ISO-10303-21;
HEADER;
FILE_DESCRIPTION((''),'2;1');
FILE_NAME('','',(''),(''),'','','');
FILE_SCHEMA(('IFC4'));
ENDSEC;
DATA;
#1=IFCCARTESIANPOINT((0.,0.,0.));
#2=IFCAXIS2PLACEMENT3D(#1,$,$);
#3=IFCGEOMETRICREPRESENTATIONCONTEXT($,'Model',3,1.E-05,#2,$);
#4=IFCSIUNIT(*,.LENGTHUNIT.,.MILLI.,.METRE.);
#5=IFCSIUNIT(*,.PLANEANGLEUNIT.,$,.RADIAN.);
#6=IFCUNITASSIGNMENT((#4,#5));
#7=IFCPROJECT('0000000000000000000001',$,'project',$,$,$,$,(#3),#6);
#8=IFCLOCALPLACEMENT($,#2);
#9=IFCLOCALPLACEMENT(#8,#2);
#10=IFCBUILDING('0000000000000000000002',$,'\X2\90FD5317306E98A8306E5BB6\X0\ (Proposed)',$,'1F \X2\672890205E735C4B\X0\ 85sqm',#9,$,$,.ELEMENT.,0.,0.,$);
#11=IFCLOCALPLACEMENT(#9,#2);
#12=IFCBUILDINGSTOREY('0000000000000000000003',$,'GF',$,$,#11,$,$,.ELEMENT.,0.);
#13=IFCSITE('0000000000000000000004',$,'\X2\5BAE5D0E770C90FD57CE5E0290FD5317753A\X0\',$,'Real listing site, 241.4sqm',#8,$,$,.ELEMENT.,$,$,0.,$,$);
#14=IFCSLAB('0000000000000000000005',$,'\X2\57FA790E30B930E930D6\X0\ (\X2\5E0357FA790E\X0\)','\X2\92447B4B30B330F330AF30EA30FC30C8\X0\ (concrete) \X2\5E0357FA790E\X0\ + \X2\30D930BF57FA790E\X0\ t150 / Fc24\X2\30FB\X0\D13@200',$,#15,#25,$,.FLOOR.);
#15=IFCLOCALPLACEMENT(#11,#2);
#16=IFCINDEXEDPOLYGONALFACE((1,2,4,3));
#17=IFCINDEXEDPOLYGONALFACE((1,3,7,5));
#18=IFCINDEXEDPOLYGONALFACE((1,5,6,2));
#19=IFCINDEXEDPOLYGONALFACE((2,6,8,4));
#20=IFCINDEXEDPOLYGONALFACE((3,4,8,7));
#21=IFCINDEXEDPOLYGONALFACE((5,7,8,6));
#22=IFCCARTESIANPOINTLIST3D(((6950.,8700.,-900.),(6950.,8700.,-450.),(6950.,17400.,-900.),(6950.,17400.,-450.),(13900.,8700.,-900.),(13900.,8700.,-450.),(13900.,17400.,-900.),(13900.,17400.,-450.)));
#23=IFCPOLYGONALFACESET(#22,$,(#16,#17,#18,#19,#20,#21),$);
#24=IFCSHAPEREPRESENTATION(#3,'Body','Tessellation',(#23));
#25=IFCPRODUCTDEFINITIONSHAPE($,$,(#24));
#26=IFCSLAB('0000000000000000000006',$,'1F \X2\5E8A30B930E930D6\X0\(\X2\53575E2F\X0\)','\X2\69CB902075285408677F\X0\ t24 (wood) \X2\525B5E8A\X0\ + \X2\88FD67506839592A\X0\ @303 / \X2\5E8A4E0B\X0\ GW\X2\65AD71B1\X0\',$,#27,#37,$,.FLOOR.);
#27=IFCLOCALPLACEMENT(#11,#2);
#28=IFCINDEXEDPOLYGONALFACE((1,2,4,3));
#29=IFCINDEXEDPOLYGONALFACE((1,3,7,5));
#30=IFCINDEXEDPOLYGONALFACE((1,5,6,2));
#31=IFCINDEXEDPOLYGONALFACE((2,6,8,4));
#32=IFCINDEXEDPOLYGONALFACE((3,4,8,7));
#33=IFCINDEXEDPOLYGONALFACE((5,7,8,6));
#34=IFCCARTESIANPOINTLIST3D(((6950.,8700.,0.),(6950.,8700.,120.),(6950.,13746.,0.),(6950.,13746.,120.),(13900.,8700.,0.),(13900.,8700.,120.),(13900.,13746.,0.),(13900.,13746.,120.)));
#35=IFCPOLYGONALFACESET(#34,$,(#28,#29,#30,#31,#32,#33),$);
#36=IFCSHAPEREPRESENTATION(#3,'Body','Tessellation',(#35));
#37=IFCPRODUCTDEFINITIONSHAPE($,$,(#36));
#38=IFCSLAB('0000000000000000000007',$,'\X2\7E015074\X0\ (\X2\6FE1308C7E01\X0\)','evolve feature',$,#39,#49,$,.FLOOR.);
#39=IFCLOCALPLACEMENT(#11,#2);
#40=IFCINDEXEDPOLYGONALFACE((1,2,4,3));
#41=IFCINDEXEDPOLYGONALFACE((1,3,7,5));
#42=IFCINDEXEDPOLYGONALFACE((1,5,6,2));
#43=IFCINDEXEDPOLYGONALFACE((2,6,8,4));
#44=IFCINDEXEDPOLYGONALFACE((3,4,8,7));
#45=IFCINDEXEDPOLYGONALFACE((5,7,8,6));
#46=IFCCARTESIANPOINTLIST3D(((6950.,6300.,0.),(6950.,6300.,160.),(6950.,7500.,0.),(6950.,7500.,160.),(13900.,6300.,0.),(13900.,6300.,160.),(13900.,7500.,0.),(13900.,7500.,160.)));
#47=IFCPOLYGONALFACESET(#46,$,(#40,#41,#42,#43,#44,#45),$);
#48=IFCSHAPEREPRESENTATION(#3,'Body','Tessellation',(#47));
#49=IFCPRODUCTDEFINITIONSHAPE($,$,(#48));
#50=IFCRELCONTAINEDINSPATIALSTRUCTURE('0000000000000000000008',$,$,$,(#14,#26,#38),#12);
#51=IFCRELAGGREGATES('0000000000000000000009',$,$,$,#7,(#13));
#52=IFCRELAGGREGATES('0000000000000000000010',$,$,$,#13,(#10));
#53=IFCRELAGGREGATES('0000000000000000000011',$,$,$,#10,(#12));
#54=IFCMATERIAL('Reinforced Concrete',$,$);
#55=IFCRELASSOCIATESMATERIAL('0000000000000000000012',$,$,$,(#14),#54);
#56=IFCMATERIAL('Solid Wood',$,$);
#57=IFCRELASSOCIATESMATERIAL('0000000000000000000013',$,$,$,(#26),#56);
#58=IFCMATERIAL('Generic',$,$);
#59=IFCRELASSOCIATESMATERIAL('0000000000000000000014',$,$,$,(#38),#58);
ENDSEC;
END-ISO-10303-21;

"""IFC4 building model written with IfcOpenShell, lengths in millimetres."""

from ifc_helpers import new_model, si_unit, frame, frame_2d, origin, place, context, project, spatial, rectangle, extrude, material, element, save


model = new_model("IFC4")

# Units and contexts
model_context = context("Model", 3, precision=1e-05, world=origin())
ifc_project = project(units=[si_unit("LENGTHUNIT", "METRE", prefix="MILLI"), si_unit("PLANEANGLEUNIT", "RADIAN")], contexts=[model_context])

# Site, building, storey
site_placement = place(None, origin())
site = spatial("IfcSite", under=ifc_project, at=site_placement, Name="宮崎県都城市都北町", ObjectType="Real listing site, 241.4sqm", CompositionType="ELEMENT", RefElevation=0.0)
building_placement = place(site_placement, origin())
building = spatial("IfcBuilding", under=site, at=building_placement, Name="都北の風の家 (Proposed)", ObjectType="1F 木造平屋 85sqm", CompositionType="ELEMENT", ElevationOfRefHeight=0.0, ElevationOfTerrain=0.0)
storey_placement = place(building_placement, origin())
storey = spatial("IfcBuildingStorey", under=building, at=storey_placement, Name="GF", CompositionType="ELEMENT", Elevation=0.0)

# Slabs
ifc_material_1 = material(Name="Reinforced Concrete")
slab_1_placement = place(storey_placement, frame((3475.0, 4350.0, -450.0)))
element("IfcSlab", 1, at=slab_1_placement, inside=storey, material=ifc_material_1, Name="基礎スラブ (布基礎)", Description="鉄筋コンクリート (concrete) 布基礎 + ベタ基礎 t150 / Fc24・D13@200", PredefinedType="FLOOR", context=model_context, shape_type="SweptSolid", body=[
    extrude(rectangle(XDim=6950.0, YDim=8700.0, at=frame_2d((3475.0, 4350.0))), frame((3475.0, 4350.0, -450.0)), (0.0, 0.0, 1.0), 450.0),
])
ifc_material_2 = material(Name="Solid Wood")
slab_2_placement = place(storey_placement, frame((3475.0, 4350.0, 0.0)))
element("IfcSlab", 2, at=slab_2_placement, inside=storey, material=ifc_material_2, Name="1F 床スラブ(南帯)", Description="構造用合板 t24 (wood) 剛床 + 製材根太 @303 / 床下 GW断熱", PredefinedType="FLOOR", context=model_context, shape_type="SweptSolid", body=[
    extrude(rectangle(XDim=6950.0, YDim=5046.0, at=frame_2d((3475.0, 2523.0))), frame((3475.0, 4350.0, 0.0)), (0.0, 0.0, 1.0), 120.0),
])
ifc_material_3 = material(Name="Generic")
slab_3_placement = place(storey_placement, frame((3475.0, 3150.0, 0.0)))
element("IfcSlab", 3, at=slab_3_placement, inside=storey, material=ifc_material_3, Name="縁側 (濡れ縁)", Description="evolve feature", PredefinedType="FLOOR", context=model_context, shape_type="SweptSolid", body=[
    extrude(rectangle(XDim=6950.0, YDim=1200.0, at=frame_2d((3475.0, 600.0))), frame((3475.0, 3150.0, 0.0)), (0.0, 0.0, 1.0), 160.0),
])

save(model, "model.ifc")
